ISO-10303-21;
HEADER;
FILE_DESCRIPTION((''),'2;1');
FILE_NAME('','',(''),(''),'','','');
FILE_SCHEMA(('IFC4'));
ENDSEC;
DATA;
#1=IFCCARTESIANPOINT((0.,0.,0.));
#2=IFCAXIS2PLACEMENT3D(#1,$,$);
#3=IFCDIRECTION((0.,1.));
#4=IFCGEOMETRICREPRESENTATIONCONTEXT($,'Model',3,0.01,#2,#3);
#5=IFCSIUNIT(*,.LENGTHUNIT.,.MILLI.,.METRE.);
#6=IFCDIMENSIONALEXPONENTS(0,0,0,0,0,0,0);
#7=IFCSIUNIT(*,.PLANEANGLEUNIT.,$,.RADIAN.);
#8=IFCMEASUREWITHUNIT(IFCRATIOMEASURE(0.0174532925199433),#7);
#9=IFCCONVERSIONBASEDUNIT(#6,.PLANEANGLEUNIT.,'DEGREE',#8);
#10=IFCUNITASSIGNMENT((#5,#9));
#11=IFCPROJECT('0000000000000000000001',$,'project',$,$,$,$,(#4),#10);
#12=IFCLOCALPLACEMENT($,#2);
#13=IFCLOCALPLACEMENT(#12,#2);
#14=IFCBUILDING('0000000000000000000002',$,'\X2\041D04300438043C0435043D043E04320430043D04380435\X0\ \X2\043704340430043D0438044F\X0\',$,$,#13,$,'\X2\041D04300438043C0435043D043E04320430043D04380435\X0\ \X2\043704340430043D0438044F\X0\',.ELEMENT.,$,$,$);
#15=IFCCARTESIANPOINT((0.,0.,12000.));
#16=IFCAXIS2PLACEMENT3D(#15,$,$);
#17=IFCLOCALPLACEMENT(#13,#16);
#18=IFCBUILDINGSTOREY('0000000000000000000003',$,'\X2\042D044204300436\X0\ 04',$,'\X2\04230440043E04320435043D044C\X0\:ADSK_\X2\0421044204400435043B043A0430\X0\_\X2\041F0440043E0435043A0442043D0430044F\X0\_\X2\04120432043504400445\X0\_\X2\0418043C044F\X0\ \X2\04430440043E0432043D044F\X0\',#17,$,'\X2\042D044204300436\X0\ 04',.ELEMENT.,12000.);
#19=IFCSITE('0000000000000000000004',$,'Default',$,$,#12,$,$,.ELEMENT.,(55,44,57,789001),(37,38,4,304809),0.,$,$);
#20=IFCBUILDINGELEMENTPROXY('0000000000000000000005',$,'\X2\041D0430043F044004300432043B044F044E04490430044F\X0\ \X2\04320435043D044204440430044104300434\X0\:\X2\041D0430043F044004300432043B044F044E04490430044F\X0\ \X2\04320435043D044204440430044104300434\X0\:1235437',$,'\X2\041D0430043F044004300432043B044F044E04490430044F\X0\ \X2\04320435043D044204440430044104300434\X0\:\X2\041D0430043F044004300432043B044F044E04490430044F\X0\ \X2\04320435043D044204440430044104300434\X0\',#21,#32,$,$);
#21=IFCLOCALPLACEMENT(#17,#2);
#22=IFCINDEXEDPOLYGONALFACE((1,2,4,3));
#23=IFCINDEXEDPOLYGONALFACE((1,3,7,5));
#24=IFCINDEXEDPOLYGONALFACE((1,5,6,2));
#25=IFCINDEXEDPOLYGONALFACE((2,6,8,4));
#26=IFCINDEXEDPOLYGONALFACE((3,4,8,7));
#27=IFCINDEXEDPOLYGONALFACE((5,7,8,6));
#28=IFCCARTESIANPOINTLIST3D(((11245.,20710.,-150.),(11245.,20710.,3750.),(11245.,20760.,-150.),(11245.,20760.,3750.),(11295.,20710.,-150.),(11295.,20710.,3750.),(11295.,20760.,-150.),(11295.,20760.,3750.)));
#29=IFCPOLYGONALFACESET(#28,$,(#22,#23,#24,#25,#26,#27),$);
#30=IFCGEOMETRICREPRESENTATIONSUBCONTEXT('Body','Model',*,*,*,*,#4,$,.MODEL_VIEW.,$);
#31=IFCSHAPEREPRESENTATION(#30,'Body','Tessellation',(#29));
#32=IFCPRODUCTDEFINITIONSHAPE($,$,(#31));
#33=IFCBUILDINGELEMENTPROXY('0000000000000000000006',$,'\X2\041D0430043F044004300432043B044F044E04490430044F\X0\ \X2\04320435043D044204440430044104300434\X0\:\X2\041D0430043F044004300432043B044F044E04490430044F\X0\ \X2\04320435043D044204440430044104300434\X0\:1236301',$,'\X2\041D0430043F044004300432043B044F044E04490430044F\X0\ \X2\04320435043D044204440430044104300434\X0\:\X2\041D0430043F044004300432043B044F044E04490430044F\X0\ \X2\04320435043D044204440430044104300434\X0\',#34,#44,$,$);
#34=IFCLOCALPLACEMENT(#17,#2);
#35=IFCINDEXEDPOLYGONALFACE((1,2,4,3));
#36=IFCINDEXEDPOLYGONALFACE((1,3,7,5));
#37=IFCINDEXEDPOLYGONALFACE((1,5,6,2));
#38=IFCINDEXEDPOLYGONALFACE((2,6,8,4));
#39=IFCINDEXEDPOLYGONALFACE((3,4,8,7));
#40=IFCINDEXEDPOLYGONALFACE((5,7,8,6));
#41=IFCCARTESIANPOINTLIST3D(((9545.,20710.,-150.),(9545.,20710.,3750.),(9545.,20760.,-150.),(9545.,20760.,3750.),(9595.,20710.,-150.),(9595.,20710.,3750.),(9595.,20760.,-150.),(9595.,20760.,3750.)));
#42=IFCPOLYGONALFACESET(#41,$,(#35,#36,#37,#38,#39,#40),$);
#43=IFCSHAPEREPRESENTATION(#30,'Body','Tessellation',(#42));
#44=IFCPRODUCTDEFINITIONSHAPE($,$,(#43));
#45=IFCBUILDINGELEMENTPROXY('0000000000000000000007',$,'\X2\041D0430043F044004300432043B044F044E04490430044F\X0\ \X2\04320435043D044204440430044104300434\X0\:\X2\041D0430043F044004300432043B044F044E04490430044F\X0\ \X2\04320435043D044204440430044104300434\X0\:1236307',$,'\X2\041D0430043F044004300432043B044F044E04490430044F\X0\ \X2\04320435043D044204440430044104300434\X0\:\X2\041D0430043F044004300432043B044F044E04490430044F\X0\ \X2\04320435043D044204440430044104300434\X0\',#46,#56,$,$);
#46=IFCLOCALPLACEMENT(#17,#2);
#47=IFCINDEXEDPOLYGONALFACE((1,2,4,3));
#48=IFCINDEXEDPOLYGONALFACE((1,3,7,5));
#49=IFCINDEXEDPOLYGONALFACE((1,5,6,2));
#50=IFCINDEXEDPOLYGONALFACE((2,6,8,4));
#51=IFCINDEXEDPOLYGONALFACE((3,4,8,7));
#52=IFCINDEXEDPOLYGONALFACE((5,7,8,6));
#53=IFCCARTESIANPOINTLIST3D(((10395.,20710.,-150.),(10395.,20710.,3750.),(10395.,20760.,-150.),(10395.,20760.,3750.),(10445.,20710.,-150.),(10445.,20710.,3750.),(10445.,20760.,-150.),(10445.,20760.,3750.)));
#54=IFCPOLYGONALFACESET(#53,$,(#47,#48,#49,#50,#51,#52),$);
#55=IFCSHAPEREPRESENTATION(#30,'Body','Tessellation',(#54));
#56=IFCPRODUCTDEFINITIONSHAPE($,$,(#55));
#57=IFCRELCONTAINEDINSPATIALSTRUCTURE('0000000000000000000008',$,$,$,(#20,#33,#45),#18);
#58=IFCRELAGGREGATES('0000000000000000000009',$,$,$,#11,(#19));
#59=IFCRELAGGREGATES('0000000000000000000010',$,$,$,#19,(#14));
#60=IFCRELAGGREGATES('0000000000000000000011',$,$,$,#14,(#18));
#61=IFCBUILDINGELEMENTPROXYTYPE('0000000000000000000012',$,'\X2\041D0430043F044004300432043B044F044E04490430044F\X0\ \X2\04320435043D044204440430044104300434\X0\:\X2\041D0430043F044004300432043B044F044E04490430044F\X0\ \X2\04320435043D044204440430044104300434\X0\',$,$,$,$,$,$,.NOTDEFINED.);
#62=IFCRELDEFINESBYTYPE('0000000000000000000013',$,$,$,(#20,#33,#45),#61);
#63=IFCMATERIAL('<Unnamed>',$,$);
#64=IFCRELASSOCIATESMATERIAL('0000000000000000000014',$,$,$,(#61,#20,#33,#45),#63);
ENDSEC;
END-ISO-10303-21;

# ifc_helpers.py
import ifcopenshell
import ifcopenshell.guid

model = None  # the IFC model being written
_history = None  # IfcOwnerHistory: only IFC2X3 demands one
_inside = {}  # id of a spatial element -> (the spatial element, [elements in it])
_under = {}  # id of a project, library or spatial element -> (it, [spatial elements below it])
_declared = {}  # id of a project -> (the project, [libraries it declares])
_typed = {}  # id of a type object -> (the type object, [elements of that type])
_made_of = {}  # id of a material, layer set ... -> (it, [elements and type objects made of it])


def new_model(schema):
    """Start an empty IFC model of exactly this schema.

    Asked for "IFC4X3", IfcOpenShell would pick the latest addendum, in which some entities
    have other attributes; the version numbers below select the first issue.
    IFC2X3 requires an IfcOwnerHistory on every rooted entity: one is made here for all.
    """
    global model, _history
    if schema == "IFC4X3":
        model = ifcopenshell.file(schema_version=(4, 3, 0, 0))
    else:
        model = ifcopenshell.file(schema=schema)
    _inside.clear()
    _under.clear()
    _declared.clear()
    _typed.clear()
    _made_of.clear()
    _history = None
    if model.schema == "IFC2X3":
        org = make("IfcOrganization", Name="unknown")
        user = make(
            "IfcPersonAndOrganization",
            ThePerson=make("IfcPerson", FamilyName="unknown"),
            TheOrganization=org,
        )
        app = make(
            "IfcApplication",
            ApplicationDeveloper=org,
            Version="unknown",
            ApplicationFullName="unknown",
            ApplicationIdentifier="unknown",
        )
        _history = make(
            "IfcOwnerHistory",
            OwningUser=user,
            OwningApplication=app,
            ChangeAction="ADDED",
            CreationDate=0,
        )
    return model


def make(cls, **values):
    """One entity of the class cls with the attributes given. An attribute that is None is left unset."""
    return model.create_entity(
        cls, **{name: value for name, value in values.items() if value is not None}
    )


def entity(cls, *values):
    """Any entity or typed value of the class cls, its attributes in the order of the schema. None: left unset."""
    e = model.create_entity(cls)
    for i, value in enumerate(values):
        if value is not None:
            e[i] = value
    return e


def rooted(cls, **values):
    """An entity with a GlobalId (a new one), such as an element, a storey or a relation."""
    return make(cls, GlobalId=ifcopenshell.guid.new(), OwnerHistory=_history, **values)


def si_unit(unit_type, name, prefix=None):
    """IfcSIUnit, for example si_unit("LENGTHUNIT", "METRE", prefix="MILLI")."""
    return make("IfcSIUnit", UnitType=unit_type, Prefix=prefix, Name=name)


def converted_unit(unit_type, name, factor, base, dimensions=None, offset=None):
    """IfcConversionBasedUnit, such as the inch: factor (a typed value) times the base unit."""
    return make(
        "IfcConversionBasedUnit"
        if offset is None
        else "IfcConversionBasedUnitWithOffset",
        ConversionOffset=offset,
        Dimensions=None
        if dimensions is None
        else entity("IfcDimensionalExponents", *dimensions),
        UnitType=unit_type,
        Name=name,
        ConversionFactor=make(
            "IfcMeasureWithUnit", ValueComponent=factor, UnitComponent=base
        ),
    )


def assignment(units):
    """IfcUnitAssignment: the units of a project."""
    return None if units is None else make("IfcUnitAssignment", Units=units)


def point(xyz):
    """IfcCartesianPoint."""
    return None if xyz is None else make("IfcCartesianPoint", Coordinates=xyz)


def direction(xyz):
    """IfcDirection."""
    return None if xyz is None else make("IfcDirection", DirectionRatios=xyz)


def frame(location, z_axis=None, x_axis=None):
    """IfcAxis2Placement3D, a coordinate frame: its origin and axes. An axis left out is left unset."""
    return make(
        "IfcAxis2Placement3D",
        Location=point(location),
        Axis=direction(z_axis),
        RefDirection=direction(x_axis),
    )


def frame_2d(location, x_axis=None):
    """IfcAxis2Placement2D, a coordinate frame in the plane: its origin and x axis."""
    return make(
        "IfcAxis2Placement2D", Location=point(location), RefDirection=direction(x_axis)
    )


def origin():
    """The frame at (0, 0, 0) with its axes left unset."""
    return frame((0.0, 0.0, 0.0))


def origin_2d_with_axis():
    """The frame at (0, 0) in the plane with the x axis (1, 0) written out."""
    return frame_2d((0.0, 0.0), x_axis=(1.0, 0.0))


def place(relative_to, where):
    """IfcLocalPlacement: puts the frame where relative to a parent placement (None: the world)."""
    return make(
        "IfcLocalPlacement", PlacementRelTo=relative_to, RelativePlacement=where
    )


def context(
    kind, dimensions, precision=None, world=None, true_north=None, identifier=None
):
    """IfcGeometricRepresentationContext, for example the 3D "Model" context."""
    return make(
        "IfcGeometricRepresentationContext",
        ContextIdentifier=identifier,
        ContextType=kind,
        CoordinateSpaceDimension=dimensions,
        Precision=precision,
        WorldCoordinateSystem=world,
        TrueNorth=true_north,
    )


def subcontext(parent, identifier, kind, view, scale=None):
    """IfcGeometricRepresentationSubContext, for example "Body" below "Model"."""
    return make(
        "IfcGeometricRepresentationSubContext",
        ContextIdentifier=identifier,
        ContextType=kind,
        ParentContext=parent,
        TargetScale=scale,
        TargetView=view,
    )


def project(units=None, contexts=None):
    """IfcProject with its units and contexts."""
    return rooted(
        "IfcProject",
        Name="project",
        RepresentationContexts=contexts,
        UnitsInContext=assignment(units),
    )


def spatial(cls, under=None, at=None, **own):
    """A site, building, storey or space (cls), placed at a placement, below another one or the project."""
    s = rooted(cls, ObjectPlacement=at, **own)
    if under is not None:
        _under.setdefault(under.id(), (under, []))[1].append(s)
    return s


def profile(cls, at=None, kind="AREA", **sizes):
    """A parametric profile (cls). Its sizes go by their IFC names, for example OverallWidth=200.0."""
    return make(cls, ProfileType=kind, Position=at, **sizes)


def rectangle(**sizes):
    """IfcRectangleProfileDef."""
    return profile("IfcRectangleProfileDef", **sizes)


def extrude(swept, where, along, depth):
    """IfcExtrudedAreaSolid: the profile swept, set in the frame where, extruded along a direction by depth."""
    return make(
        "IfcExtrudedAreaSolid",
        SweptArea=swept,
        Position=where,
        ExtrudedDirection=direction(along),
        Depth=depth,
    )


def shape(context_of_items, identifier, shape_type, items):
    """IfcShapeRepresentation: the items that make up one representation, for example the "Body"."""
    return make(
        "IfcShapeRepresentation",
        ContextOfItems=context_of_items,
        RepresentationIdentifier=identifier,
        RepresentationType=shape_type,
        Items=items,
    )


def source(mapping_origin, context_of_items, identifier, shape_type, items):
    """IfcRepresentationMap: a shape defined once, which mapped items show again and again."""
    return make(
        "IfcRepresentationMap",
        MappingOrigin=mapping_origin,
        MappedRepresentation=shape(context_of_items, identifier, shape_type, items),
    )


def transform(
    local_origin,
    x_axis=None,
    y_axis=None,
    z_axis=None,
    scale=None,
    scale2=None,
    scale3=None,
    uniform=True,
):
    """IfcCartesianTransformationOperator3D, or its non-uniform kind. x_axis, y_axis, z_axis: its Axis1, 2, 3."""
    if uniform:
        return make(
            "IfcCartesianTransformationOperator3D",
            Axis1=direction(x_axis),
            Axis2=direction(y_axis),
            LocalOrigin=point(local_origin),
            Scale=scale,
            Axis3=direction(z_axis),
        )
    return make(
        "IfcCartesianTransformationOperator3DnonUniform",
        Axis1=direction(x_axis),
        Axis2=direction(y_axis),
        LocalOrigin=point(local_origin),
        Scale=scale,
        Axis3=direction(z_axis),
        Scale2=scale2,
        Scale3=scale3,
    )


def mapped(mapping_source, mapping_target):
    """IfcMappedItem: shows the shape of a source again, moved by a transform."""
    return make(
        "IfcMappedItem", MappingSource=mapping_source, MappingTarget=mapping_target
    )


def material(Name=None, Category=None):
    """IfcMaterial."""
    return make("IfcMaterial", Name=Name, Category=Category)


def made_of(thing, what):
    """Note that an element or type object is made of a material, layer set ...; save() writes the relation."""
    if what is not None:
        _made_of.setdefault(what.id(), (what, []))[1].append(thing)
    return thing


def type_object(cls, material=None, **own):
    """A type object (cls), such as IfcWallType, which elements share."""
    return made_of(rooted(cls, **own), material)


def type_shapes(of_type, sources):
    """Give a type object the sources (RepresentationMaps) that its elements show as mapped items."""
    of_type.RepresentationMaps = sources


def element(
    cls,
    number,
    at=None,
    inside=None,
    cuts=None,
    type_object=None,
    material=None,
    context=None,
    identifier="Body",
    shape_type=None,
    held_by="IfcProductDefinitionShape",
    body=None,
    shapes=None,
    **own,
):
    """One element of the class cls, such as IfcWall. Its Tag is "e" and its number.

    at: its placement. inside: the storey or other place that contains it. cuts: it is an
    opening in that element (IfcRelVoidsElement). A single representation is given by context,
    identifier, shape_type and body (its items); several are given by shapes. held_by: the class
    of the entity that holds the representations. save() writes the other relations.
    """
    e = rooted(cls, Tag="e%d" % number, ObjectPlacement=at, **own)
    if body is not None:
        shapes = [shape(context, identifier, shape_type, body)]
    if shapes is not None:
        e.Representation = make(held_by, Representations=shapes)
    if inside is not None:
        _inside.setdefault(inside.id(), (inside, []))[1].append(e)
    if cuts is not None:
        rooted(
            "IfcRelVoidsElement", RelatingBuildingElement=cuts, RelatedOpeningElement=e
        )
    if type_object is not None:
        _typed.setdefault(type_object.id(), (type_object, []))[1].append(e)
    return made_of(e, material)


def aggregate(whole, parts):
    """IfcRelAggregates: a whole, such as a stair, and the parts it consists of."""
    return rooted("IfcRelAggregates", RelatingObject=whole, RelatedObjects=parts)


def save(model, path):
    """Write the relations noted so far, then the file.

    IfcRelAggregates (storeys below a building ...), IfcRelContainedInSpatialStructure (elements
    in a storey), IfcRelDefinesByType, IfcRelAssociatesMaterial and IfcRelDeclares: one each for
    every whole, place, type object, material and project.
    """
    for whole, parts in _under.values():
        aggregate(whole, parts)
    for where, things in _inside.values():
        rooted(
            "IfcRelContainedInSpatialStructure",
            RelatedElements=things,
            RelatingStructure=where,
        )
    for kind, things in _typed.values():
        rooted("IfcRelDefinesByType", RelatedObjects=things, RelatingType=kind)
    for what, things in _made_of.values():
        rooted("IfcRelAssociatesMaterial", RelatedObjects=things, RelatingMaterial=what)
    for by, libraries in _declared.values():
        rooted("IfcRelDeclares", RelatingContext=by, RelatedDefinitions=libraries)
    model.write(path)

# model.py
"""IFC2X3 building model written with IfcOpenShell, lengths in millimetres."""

from ifc_helpers import new_model, entity, si_unit, converted_unit, direction, frame, origin, origin_2d_with_axis, place, context, subcontext, project, spatial, rectangle, extrude, source, transform, mapped, material, type_object, type_shapes, element, save


model = new_model("IFC2X3")

# Units and contexts
model_context = context("Model", 3, precision=0.01, world=origin(), true_north=direction((0.0, 1.0)))
body_context = subcontext(model_context, "Body", "Model", "MODEL_VIEW")
ifc_project = project(units=[si_unit("LENGTHUNIT", "METRE", prefix="MILLI"), converted_unit("PLANEANGLEUNIT", "DEGREE", entity("IfcRatioMeasure", 0.0174532925199433), si_unit("PLANEANGLEUNIT", "RADIAN"), dimensions=[0, 0, 0, 0, 0, 0, 0])], contexts=[model_context])

# Site, building, storey
site_placement = place(None, origin())
site = spatial("IfcSite", under=ifc_project, at=site_placement, Name="Default", CompositionType="ELEMENT", RefLatitude=(55, 44, 57, 789001), RefLongitude=(37, 38, 4, 304809), RefElevation=0.0)
building_placement = place(site_placement, origin())
building = spatial("IfcBuilding", under=site, at=building_placement, Name="Наименование здания", LongName="Наименование здания", CompositionType="ELEMENT")
storey_placement = place(building_placement, frame((0.0, 0.0, 12000.0)))
storey = spatial("IfcBuildingStorey", under=building, at=storey_placement, Name="Этаж 04", ObjectType="Уровень:ADSK_Стрелка_Проектная_Вверх_Имя уровня", LongName="Этаж 04", CompositionType="ELEMENT", Elevation=12000.0)

# Building element proxies
ifc_material_1 = material(Name="<Unnamed>")
building_element_proxy_type_1 = type_object("IfcBuildingElementProxyType", Name="Направляющая вентфасад:Направляющая вентфасад", PredefinedType="NOTDEFINED", material=ifc_material_1)
shared_shape_1 = source(origin(), body_context, "Body", "SweptSolid", [
    extrude(rectangle(XDim=50.0, YDim=50.0, at=origin_2d_with_axis()), frame((25.0, 25.0, 0.0), z_axis=(0.0, 0.0, 1.0), x_axis=(0.0, 1.0, 0.0)), (0.0, 0.0, 1.0), 3900.0),
])
type_shapes(building_element_proxy_type_1, [shared_shape_1])
for number, where, name in (
    (1, (11245.0, 20710.0, -150.0), "Направляющая вентфасад:Направляющая вентфасад:1235437"),
    (2, (9545.0, 20710.0, -150.0), "Направляющая вентфасад:Направляющая вентфасад:1236301"),
    (3, (10395.0, 20710.0, -150.0), "Направляющая вентфасад:Направляющая вентфасад:1236307"),
):
    element("IfcBuildingElementProxy", number, at=place(storey_placement, frame(where)), inside=storey, type_object=building_element_proxy_type_1, material=ifc_material_1, Name=name, ObjectType="Направляющая вентфасад:Направляющая вентфасад", context=body_context, shape_type="MappedRepresentation", body=[
        mapped(shared_shape_1, transform((0.0, 0.0, 0.0), scale=1.0)),
    ])

save(model, "model.ifc")
